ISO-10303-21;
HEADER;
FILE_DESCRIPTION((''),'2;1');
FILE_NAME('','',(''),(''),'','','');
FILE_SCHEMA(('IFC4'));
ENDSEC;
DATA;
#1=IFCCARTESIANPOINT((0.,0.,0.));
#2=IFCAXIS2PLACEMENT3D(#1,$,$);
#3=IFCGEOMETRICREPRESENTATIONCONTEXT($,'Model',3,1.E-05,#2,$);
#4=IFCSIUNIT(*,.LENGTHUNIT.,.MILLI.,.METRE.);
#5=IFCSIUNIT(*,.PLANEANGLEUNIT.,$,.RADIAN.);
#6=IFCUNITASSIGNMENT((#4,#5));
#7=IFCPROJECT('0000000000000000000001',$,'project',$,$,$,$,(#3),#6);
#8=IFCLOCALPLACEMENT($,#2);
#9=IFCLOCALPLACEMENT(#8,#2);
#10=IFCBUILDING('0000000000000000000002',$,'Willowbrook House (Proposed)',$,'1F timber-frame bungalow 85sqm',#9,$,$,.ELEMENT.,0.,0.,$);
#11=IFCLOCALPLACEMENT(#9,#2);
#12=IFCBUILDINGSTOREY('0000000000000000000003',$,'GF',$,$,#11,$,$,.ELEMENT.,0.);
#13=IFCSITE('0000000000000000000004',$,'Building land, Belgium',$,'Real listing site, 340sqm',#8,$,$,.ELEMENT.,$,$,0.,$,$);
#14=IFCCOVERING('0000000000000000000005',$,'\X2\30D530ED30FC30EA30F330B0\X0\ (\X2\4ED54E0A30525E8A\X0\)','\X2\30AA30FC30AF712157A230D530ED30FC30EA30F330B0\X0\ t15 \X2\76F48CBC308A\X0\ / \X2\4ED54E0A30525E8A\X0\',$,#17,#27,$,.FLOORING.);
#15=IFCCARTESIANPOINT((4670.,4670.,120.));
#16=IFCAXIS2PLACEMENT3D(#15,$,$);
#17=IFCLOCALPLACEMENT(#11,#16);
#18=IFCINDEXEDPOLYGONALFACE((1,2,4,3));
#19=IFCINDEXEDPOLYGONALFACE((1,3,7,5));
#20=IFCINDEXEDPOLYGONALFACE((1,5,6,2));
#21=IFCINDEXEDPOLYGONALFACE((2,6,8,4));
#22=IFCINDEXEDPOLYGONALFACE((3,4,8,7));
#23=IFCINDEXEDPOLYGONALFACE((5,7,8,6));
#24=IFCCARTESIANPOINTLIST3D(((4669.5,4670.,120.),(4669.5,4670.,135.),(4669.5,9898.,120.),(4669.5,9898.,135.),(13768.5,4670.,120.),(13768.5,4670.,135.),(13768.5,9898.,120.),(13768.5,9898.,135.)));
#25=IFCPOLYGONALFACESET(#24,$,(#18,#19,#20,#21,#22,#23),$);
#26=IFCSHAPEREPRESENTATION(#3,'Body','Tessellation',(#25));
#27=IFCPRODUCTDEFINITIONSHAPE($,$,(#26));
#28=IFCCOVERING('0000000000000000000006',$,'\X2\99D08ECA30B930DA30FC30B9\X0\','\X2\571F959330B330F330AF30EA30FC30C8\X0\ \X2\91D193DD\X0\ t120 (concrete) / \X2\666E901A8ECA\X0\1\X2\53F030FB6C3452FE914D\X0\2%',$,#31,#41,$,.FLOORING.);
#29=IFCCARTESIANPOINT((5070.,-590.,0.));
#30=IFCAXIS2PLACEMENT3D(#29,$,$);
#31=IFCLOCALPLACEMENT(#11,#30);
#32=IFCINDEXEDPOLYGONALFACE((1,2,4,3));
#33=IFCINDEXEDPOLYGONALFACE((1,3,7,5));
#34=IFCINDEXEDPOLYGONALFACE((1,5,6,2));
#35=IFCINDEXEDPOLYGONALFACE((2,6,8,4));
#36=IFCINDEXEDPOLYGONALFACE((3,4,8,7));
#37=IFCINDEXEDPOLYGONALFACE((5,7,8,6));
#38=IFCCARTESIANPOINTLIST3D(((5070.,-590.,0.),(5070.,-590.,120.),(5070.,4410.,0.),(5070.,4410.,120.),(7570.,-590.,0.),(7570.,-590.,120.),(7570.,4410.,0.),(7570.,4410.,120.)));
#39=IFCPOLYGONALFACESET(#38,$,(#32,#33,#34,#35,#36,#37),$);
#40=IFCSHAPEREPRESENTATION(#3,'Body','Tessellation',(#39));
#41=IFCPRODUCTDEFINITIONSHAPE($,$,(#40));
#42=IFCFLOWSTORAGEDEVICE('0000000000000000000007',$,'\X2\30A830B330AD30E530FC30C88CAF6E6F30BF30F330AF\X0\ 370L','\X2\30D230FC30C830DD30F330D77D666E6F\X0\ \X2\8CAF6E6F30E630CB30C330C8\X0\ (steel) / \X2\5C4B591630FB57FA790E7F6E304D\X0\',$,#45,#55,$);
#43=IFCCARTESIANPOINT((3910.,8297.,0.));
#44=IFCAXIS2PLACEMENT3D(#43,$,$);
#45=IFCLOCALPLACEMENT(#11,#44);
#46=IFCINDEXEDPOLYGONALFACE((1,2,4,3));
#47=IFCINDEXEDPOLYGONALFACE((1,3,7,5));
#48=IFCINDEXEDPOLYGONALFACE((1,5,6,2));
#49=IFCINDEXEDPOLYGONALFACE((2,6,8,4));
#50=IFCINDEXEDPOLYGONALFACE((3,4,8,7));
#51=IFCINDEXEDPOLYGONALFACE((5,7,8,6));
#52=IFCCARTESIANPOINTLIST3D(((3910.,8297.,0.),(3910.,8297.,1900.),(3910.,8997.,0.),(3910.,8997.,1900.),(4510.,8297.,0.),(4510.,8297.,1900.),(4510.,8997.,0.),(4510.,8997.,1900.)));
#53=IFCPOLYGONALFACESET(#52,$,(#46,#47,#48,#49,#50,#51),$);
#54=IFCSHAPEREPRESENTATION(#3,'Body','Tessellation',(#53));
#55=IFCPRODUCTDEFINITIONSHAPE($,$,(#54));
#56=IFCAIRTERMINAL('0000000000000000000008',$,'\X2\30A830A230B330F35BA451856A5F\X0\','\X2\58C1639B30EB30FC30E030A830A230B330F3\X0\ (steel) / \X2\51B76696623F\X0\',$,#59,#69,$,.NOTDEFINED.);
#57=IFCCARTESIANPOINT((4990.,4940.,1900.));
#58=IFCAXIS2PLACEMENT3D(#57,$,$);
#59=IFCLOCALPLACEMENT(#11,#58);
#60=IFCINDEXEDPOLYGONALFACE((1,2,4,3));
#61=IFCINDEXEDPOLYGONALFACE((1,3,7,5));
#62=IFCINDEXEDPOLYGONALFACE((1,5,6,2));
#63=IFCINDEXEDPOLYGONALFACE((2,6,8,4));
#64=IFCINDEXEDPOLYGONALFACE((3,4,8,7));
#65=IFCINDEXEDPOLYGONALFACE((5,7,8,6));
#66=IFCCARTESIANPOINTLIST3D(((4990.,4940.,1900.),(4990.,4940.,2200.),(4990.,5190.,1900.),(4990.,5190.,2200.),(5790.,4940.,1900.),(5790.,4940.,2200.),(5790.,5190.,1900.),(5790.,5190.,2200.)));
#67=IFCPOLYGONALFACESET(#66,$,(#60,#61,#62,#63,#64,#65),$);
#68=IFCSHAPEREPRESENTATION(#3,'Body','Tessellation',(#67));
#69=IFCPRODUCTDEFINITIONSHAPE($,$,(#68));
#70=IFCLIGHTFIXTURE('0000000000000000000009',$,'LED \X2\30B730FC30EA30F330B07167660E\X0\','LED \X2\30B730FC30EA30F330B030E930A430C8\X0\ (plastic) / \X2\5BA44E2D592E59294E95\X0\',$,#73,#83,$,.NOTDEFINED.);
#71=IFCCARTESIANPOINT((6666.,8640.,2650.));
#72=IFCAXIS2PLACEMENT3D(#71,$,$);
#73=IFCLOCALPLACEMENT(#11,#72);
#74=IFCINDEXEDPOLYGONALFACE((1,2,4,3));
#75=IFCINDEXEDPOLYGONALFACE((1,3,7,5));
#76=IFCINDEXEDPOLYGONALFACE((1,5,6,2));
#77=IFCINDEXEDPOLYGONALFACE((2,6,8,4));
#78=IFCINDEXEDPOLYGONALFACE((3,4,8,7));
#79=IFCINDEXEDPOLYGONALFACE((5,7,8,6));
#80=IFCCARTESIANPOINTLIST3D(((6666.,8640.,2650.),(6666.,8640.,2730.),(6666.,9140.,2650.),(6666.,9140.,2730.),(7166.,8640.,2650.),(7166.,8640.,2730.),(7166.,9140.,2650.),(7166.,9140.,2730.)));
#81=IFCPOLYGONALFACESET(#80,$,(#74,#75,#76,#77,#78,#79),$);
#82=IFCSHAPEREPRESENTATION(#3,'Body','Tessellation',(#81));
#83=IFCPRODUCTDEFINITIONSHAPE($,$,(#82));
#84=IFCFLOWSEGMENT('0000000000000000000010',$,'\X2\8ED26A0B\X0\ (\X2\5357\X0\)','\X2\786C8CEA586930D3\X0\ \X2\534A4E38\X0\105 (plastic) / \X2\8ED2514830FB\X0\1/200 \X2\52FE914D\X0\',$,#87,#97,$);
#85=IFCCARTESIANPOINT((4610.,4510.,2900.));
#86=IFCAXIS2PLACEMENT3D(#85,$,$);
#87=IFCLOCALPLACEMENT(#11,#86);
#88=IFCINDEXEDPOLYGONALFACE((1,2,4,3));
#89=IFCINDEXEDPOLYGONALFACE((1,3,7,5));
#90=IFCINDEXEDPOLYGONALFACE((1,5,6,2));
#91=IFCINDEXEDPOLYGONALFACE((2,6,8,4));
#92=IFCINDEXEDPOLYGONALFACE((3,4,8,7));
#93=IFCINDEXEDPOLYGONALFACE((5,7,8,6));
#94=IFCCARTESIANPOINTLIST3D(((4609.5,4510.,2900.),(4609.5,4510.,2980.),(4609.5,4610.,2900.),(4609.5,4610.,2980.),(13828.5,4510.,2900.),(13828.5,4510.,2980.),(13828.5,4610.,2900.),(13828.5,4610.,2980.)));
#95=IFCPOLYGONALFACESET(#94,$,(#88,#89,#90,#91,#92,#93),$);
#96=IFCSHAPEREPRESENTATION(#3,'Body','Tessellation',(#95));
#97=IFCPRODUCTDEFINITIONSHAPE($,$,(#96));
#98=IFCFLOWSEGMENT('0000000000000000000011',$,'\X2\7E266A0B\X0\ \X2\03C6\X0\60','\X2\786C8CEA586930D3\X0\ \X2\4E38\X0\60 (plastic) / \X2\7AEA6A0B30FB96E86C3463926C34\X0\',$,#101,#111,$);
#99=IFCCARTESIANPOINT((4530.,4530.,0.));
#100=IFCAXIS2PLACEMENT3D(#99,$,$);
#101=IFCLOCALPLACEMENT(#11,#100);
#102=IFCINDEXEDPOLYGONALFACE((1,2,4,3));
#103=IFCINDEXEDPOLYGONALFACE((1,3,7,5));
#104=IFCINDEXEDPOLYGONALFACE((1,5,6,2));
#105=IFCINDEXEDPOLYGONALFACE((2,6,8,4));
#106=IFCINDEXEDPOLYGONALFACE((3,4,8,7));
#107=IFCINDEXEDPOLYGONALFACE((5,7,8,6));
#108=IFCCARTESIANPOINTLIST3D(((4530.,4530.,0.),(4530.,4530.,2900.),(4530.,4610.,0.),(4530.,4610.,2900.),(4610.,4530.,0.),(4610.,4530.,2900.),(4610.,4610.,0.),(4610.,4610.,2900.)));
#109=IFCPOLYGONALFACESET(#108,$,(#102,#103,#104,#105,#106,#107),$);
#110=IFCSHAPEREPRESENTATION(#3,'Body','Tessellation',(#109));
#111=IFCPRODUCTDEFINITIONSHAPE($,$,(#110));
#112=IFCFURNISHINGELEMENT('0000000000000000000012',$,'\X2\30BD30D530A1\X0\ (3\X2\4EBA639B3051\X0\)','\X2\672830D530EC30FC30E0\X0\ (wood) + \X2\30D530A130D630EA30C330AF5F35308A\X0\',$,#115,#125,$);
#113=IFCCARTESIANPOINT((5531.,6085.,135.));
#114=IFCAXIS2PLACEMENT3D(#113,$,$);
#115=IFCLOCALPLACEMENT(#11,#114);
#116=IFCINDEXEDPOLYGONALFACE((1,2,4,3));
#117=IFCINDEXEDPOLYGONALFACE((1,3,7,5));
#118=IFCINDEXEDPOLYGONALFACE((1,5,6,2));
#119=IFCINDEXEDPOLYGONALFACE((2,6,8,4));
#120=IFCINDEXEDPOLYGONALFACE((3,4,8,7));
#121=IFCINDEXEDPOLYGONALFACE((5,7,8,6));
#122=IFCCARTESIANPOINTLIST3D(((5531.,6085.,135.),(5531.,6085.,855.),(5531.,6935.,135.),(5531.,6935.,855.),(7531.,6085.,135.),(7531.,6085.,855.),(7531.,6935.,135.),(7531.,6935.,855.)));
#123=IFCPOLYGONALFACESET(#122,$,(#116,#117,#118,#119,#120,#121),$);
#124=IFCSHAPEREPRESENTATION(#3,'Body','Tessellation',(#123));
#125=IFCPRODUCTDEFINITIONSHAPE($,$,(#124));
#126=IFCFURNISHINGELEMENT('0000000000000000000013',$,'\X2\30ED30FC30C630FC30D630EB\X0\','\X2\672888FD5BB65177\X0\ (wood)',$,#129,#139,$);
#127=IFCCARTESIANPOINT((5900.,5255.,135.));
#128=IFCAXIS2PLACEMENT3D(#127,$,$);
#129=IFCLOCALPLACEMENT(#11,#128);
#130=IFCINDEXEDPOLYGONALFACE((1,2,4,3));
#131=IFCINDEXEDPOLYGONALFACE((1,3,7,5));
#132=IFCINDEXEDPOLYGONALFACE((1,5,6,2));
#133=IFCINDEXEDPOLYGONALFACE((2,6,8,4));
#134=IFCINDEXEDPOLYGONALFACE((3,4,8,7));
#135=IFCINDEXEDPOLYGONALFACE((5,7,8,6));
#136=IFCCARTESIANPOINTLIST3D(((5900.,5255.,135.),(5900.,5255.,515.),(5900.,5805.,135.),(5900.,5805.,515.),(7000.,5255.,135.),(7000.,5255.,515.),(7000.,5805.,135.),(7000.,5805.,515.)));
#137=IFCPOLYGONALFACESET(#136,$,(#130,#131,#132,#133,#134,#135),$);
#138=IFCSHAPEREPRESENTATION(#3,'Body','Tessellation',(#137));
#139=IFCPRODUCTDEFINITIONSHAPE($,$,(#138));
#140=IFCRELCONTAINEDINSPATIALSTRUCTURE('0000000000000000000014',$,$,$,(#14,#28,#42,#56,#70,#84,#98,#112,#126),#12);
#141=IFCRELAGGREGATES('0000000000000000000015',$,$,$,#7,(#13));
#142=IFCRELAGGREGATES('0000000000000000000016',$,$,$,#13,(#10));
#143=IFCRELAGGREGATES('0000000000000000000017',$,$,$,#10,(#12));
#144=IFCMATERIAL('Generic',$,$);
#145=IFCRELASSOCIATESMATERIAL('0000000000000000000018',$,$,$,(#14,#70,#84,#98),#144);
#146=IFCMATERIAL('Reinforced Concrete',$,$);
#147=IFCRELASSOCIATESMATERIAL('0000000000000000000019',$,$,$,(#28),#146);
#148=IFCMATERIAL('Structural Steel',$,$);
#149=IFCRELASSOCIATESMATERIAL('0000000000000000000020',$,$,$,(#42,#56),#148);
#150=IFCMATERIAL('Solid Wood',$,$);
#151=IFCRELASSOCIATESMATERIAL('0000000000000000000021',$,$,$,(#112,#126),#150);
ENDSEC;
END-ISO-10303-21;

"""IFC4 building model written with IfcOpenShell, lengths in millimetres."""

from ifc_helpers import new_model, si_unit, frame, frame_2d, origin, place, context, project, spatial, rectangle, extrude, material, element, save


model = new_model("IFC4")

# Units and contexts
model_context = context("Model", 3, precision=1e-05, world=origin())
ifc_project = project(units=[si_unit("LENGTHUNIT", "METRE", prefix="MILLI"), si_unit("PLANEANGLEUNIT", "RADIAN")], contexts=[model_context])

# Site, building, storey
site_placement = place(None, origin())
site = spatial("IfcSite", under=ifc_project, at=site_placement, Name="Building land, Belgium", ObjectType="Real listing site, 340sqm", CompositionType="ELEMENT", RefElevation=0.0)
building_placement = place(site_placement, origin())
building = spatial("IfcBuilding", under=site, at=building_placement, Name="Willowbrook House (Proposed)", ObjectType="1F timber-frame bungalow 85sqm", CompositionType="ELEMENT", ElevationOfRefHeight=0.0, ElevationOfTerrain=0.0)
storey_placement = place(building_placement, origin())
storey = spatial("IfcBuildingStorey", under=building, at=storey_placement, Name="GF", CompositionType="ELEMENT", Elevation=0.0)

# Shared definitions
ifc_material_1 = material(Name="Solid Wood")

# Shared definitions
ifc_material_2 = material(Name="Reinforced Concrete")

# Shared definitions
ifc_material_3 = material(Name="Structural Steel")

# Coverings
ifc_material_4 = material(Name="Generic")
covering_1_placement = place(storey_placement, frame((4670.0, 4670.0, 120.0)))
element("IfcCovering", 1, at=covering_1_placement, inside=storey, material=ifc_material_4, Name="フローリング (仕上げ床)", Description="オーク無垢フローリング t15 直貼り / 仕上げ床", PredefinedType="FLOORING", context=model_context, shape_type="SweptSolid", body=[
    extrude(rectangle(XDim=9099.0, YDim=5228.0, at=frame_2d((4549.0, 2614.0))), frame((4670.0, 4670.0, 120.0)), (0.0, 0.0, 1.0), 15.0),
])
covering_2_placement = place(storey_placement, frame((5070.0, -590.0, 0.0)))
element("IfcCovering", 2, at=covering_2_placement, inside=storey, material=ifc_material_2, Name="駐車スペース", Description="土間コンクリート 金鏝 t120 (concrete) / 普通車1台・水勾配2%", PredefinedType="FLOORING", context=model_context, shape_type="SweptSolid", body=[
    extrude(rectangle(XDim=2500.0, YDim=5000.0, at=frame_2d((1250.0, 2500.0))), frame((5070.0, -590.0, 0.0)), (0.0, 0.0, 1.0), 120.0),
])

# Flow storage device
flow_storage_device_placement = place(storey_placement, frame((3910.0, 8297.0, 0.0)))
element("IfcFlowStorageDevice", 3, at=flow_storage_device_placement, inside=storey, material=ifc_material_3, Name="エコキュート貯湯タンク 370L", Description="ヒートポンプ給湯 貯湯ユニット (steel) / 屋外・基礎置き", context=model_context, shape_type="SweptSolid", body=[
    extrude(rectangle(XDim=600.0, YDim=700.0, at=frame_2d((300.0, 350.0))), frame((3910.0, 8297.0, 0.0)), (0.0, 0.0, 1.0), 1900.0),
])

# Air terminal
air_terminal_placement = place(storey_placement, frame((4990.0, 4940.0, 1900.0)))
element("IfcAirTerminal", 4, at=air_terminal_placement, inside=storey, material=ifc_material_3, Name="エアコン室内機", Description="壁掛ルームエアコン (steel) / 冷暖房", PredefinedType="NOTDEFINED", context=model_context, shape_type="SweptSolid", body=[
    extrude(rectangle(XDim=800.0, YDim=250.0, at=frame_2d((400.0, 125.0))), frame((4990.0, 4940.0, 1900.0)), (0.0, 0.0, 1.0), 300.0),
])

# Light fixture
light_fixture_placement = place(storey_placement, frame((6666.0, 8640.0, 2650.0)))
element("IfcLightFixture", 5, at=light_fixture_placement, inside=storey, material=ifc_material_4, Name="LED シーリング照明", Description="LED シーリングライト (plastic) / 室中央天井", PredefinedType="NOTDEFINED", context=model_context, shape_type="SweptSolid", body=[
    extrude(rectangle(XDim=500.0, YDim=500.0, at=frame_2d((250.0, 250.0))), frame((6666.0, 8640.0, 2650.0)), (0.0, 0.0, 1.0), 80.0),
])

# Flow segments
flow_segment_1_placement = place(storey_placement, frame((4610.0, 4510.0, 2900.0)))
element("IfcFlowSegment", 6, at=flow_segment_1_placement, inside=storey, material=ifc_material_4, Name="軒樋 (南)", Description="硬質塩ビ 半丸105 (plastic) / 軒先・1/200 勾配", context=model_context, shape_type="SweptSolid", body=[
    extrude(rectangle(XDim=9219.0, YDim=100.0, at=frame_2d((4609.0, 50.0))), frame((4610.0, 4510.0, 2900.0)), (0.0, 0.0, 1.0), 80.0),
])
flow_segment_2_placement = place(storey_placement, frame((4530.0, 4530.0, 0.0)))
element("IfcFlowSegment", 7, at=flow_segment_2_placement, inside=storey, material=ifc_material_4, Name="縦樋 φ60", Description="硬質塩ビ 丸60 (plastic) / 竪樋・雨水排水", context=model_context, shape_type="SweptSolid", body=[
    extrude(rectangle(XDim=80.0, YDim=80.0, at=frame_2d((40.0, 40.0))), frame((4530.0, 4530.0, 0.0)), (0.0, 0.0, 1.0), 2900.0),
])

# Furnishing elements
furnishing_1_placement = place(storey_placement, frame((5531.0, 6085.0, 135.0)))
element("IfcFurnishingElement", 8, at=furnishing_1_placement, inside=storey, material=ifc_material_1, Name="ソファ (3人掛け)", Description="木フレーム (wood) + ファブリック張り", context=model_context, shape_type="SweptSolid", body=[
    extrude(rectangle(XDim=2000.0, YDim=850.0, at=frame_2d((1000.0, 425.0))), frame((5531.0, 6085.0, 135.0)), (0.0, 0.0, 1.0), 720.0),
])
furnishing_2_placement = place(storey_placement, frame((5900.0, 5255.0, 135.0)))
element("IfcFurnishingElement", 9, at=furnishing_2_placement, inside=storey, material=ifc_material_1, Name="ローテーブル", Description="木製家具 (wood)", context=model_context, shape_type="SweptSolid", body=[
    extrude(rectangle(XDim=1100.0, YDim=550.0, at=frame_2d((550.0, 275.0))), frame((5900.0, 5255.0, 135.0)), (0.0, 0.0, 1.0), 380.0),
])

save(model, "model.ifc")
